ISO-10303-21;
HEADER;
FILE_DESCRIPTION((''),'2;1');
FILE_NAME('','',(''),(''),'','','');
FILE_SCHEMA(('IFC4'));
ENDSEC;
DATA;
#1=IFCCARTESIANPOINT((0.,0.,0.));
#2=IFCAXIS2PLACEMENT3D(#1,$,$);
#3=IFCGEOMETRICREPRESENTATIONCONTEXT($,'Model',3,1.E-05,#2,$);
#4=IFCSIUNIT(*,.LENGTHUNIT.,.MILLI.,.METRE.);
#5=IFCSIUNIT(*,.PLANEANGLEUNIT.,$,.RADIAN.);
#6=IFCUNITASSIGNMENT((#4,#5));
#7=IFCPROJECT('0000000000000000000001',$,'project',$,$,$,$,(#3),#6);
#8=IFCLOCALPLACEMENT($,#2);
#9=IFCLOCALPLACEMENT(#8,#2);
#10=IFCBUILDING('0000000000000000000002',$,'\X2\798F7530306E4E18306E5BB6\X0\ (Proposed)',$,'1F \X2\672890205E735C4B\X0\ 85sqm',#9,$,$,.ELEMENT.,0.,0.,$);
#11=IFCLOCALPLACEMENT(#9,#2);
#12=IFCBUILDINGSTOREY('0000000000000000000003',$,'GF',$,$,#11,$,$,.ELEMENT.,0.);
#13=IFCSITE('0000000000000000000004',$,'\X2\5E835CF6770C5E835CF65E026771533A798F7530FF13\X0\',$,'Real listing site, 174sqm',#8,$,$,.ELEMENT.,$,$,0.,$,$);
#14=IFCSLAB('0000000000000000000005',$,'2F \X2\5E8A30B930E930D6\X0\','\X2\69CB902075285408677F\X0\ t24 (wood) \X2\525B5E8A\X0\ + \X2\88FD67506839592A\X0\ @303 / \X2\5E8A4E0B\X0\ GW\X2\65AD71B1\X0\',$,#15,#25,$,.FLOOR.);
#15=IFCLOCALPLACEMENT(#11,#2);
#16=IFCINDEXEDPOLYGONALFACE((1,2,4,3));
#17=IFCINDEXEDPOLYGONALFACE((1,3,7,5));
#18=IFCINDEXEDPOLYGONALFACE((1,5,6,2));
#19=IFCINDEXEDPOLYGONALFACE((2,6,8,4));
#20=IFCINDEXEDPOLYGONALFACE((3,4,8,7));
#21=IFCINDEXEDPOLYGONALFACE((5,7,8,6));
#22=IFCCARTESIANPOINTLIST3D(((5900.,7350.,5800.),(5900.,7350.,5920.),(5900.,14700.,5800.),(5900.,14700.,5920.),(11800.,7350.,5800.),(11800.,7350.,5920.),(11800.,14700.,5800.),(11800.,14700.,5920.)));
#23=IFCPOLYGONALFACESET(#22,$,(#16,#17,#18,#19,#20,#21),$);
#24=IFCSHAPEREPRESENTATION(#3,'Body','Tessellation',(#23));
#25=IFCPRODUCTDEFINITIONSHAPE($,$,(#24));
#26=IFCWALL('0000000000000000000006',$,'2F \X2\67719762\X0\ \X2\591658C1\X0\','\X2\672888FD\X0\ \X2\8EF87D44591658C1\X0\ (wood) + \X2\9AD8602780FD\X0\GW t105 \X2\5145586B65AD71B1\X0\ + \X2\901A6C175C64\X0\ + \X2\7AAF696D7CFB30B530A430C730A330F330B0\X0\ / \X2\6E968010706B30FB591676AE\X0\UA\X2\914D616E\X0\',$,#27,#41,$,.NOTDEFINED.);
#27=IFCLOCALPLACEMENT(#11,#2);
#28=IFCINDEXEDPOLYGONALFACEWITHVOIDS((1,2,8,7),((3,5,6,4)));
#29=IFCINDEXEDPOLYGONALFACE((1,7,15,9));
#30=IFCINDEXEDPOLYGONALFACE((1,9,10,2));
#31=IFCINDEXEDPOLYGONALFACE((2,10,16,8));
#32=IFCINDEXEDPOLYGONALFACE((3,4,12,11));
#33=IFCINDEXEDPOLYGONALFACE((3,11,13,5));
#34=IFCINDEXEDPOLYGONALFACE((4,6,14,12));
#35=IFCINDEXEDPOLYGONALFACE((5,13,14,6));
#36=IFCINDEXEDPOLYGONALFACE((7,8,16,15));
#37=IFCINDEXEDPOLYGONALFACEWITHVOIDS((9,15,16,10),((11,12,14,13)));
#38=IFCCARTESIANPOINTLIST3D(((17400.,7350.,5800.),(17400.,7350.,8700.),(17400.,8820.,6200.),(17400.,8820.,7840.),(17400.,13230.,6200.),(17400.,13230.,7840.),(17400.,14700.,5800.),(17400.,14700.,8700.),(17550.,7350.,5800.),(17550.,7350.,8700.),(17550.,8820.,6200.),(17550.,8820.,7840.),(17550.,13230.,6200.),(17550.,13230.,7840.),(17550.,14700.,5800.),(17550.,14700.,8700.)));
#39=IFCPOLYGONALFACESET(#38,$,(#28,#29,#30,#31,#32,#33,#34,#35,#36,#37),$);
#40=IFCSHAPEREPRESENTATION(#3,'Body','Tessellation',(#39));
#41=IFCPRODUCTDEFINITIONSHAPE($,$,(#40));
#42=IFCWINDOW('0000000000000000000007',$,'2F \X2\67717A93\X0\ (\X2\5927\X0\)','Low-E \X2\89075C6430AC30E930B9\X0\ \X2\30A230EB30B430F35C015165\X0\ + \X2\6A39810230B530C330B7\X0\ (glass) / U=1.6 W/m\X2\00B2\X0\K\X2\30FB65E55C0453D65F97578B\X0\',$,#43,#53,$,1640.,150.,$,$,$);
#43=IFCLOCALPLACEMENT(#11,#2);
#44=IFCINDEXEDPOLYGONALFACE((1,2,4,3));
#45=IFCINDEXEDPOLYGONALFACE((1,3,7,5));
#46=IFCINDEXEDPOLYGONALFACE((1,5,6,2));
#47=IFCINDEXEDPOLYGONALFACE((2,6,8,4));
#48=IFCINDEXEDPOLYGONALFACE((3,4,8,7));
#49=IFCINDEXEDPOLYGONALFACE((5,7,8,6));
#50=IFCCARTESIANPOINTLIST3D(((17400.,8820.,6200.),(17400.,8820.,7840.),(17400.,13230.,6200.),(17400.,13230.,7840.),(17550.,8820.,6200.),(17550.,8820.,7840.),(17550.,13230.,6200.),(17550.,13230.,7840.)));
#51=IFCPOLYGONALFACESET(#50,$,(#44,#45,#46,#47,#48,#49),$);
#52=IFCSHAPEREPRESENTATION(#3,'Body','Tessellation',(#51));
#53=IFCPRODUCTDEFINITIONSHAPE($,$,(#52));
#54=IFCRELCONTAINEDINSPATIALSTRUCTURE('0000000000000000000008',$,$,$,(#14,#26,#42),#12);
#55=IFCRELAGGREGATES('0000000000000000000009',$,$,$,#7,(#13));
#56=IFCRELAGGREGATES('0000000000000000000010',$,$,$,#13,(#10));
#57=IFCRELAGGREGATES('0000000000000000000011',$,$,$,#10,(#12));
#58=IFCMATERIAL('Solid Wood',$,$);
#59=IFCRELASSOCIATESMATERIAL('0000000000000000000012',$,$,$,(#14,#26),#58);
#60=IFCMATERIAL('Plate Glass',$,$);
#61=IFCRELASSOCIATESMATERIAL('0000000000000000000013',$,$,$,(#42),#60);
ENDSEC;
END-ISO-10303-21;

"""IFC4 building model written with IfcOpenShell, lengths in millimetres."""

from ifc_helpers import new_model, si_unit, frame, frame_2d, origin, place, context, project, spatial, rectangle, extrude, material, element, fill, save


model = new_model("IFC4")

# Units and contexts
model_context = context("Model", 3, precision=1e-05, world=origin())
ifc_project = project(units=[si_unit("LENGTHUNIT", "METRE", prefix="MILLI"), si_unit("PLANEANGLEUNIT", "RADIAN")], contexts=[model_context])

# Site, building, storey
site_placement = place(None, origin())
site = spatial("IfcSite", under=ifc_project, at=site_placement, Name="広島県広島市東区福田３", ObjectType="Real listing site, 174sqm", CompositionType="ELEMENT", RefElevation=0.0)
building_placement = place(site_placement, origin())
building = spatial("IfcBuilding", under=site, at=building_placement, Name="福田の丘の家 (Proposed)", ObjectType="1F 木造平屋 85sqm", CompositionType="ELEMENT", ElevationOfRefHeight=0.0, ElevationOfTerrain=0.0)
storey_placement = place(building_placement, origin())
storey = spatial("IfcBuildingStorey", under=building, at=storey_placement, Name="GF", CompositionType="ELEMENT", Elevation=0.0)

# Slab
ifc_material_1 = material(Name="Solid Wood")
slab_placement = place(storey_placement, frame((2950.0, 3675.0, 2900.0)))
element("IfcSlab", 1, at=slab_placement, inside=storey, material=ifc_material_1, Name="2F 床スラブ", Description="構造用合板 t24 (wood) 剛床 + 製材根太 @303 / 床下 GW断熱", PredefinedType="FLOOR", context=model_context, shape_type="SweptSolid", body=[
    extrude(rectangle(XDim=5900.0, YDim=7350.0, at=frame_2d((2950.0, 3675.0))), frame((2950.0, 3675.0, 2900.0)), (0.0, 0.0, 1.0), 120.0),
])

# Shared definitions
ifc_material_2 = material(Name="Plate Glass")

# Wall, opening, window
wall_1_placement = place(storey_placement, frame((8700.0, 3675.0, 2900.0)))
wall_1 = element("IfcWall", 2, at=wall_1_placement, inside=storey, material=ifc_material_1, Name="2F 東面 外壁", Description="木製 軸組外壁 (wood) + 高性能GW t105 充填断熱 + 通気層 + 窯業系サイディング / 準耐火・外皮UA配慮", PredefinedType="NOTDEFINED", context=model_context, shape_type="SweptSolid", body=[
    extrude(rectangle(XDim=150.0, YDim=7350.0, at=frame_2d((75.0, 3675.0))), frame((8700.0, 3675.0, 2900.0)), (0.0, 0.0, 1.0), 2900.0),
])
opening_1_placement = place(storey_placement, frame((8700.0, 4410.0, 3100.0)))
opening_1 = element("IfcOpeningElement", 3, at=opening_1_placement, cuts=wall_1, PredefinedType="NOTDEFINED", context=model_context, shape_type="SweptSolid", body=[
    extrude(rectangle(XDim=150.0, YDim=4410.0, at=frame_2d((75.0, 2205.0))), frame((8700.0, 4410.0, 3100.0)), (0.0, 0.0, 1.0), 1640.0),
])
window_1_placement = place(storey_placement, frame((8700.0, 4410.0, 3100.0)))
window_1 = element("IfcWindow", 4, at=window_1_placement, inside=storey, material=ifc_material_2, Name="2F 東窓 (大)", Description="Low-E 複層ガラス アルゴン封入 + 樹脂サッシ (glass) / U=1.6 W/m²K・日射取得型", OverallHeight=1640.0, OverallWidth=150.0, context=model_context, shape_type="SweptSolid", body=[
    extrude(rectangle(XDim=150.0, YDim=4410.0, at=frame_2d((75.0, 2205.0))), frame((8700.0, 4410.0, 3100.0)), (0.0, 0.0, 1.0), 1640.0),
])
fill(opening_1, window_1)

save(model, "model.ifc")
